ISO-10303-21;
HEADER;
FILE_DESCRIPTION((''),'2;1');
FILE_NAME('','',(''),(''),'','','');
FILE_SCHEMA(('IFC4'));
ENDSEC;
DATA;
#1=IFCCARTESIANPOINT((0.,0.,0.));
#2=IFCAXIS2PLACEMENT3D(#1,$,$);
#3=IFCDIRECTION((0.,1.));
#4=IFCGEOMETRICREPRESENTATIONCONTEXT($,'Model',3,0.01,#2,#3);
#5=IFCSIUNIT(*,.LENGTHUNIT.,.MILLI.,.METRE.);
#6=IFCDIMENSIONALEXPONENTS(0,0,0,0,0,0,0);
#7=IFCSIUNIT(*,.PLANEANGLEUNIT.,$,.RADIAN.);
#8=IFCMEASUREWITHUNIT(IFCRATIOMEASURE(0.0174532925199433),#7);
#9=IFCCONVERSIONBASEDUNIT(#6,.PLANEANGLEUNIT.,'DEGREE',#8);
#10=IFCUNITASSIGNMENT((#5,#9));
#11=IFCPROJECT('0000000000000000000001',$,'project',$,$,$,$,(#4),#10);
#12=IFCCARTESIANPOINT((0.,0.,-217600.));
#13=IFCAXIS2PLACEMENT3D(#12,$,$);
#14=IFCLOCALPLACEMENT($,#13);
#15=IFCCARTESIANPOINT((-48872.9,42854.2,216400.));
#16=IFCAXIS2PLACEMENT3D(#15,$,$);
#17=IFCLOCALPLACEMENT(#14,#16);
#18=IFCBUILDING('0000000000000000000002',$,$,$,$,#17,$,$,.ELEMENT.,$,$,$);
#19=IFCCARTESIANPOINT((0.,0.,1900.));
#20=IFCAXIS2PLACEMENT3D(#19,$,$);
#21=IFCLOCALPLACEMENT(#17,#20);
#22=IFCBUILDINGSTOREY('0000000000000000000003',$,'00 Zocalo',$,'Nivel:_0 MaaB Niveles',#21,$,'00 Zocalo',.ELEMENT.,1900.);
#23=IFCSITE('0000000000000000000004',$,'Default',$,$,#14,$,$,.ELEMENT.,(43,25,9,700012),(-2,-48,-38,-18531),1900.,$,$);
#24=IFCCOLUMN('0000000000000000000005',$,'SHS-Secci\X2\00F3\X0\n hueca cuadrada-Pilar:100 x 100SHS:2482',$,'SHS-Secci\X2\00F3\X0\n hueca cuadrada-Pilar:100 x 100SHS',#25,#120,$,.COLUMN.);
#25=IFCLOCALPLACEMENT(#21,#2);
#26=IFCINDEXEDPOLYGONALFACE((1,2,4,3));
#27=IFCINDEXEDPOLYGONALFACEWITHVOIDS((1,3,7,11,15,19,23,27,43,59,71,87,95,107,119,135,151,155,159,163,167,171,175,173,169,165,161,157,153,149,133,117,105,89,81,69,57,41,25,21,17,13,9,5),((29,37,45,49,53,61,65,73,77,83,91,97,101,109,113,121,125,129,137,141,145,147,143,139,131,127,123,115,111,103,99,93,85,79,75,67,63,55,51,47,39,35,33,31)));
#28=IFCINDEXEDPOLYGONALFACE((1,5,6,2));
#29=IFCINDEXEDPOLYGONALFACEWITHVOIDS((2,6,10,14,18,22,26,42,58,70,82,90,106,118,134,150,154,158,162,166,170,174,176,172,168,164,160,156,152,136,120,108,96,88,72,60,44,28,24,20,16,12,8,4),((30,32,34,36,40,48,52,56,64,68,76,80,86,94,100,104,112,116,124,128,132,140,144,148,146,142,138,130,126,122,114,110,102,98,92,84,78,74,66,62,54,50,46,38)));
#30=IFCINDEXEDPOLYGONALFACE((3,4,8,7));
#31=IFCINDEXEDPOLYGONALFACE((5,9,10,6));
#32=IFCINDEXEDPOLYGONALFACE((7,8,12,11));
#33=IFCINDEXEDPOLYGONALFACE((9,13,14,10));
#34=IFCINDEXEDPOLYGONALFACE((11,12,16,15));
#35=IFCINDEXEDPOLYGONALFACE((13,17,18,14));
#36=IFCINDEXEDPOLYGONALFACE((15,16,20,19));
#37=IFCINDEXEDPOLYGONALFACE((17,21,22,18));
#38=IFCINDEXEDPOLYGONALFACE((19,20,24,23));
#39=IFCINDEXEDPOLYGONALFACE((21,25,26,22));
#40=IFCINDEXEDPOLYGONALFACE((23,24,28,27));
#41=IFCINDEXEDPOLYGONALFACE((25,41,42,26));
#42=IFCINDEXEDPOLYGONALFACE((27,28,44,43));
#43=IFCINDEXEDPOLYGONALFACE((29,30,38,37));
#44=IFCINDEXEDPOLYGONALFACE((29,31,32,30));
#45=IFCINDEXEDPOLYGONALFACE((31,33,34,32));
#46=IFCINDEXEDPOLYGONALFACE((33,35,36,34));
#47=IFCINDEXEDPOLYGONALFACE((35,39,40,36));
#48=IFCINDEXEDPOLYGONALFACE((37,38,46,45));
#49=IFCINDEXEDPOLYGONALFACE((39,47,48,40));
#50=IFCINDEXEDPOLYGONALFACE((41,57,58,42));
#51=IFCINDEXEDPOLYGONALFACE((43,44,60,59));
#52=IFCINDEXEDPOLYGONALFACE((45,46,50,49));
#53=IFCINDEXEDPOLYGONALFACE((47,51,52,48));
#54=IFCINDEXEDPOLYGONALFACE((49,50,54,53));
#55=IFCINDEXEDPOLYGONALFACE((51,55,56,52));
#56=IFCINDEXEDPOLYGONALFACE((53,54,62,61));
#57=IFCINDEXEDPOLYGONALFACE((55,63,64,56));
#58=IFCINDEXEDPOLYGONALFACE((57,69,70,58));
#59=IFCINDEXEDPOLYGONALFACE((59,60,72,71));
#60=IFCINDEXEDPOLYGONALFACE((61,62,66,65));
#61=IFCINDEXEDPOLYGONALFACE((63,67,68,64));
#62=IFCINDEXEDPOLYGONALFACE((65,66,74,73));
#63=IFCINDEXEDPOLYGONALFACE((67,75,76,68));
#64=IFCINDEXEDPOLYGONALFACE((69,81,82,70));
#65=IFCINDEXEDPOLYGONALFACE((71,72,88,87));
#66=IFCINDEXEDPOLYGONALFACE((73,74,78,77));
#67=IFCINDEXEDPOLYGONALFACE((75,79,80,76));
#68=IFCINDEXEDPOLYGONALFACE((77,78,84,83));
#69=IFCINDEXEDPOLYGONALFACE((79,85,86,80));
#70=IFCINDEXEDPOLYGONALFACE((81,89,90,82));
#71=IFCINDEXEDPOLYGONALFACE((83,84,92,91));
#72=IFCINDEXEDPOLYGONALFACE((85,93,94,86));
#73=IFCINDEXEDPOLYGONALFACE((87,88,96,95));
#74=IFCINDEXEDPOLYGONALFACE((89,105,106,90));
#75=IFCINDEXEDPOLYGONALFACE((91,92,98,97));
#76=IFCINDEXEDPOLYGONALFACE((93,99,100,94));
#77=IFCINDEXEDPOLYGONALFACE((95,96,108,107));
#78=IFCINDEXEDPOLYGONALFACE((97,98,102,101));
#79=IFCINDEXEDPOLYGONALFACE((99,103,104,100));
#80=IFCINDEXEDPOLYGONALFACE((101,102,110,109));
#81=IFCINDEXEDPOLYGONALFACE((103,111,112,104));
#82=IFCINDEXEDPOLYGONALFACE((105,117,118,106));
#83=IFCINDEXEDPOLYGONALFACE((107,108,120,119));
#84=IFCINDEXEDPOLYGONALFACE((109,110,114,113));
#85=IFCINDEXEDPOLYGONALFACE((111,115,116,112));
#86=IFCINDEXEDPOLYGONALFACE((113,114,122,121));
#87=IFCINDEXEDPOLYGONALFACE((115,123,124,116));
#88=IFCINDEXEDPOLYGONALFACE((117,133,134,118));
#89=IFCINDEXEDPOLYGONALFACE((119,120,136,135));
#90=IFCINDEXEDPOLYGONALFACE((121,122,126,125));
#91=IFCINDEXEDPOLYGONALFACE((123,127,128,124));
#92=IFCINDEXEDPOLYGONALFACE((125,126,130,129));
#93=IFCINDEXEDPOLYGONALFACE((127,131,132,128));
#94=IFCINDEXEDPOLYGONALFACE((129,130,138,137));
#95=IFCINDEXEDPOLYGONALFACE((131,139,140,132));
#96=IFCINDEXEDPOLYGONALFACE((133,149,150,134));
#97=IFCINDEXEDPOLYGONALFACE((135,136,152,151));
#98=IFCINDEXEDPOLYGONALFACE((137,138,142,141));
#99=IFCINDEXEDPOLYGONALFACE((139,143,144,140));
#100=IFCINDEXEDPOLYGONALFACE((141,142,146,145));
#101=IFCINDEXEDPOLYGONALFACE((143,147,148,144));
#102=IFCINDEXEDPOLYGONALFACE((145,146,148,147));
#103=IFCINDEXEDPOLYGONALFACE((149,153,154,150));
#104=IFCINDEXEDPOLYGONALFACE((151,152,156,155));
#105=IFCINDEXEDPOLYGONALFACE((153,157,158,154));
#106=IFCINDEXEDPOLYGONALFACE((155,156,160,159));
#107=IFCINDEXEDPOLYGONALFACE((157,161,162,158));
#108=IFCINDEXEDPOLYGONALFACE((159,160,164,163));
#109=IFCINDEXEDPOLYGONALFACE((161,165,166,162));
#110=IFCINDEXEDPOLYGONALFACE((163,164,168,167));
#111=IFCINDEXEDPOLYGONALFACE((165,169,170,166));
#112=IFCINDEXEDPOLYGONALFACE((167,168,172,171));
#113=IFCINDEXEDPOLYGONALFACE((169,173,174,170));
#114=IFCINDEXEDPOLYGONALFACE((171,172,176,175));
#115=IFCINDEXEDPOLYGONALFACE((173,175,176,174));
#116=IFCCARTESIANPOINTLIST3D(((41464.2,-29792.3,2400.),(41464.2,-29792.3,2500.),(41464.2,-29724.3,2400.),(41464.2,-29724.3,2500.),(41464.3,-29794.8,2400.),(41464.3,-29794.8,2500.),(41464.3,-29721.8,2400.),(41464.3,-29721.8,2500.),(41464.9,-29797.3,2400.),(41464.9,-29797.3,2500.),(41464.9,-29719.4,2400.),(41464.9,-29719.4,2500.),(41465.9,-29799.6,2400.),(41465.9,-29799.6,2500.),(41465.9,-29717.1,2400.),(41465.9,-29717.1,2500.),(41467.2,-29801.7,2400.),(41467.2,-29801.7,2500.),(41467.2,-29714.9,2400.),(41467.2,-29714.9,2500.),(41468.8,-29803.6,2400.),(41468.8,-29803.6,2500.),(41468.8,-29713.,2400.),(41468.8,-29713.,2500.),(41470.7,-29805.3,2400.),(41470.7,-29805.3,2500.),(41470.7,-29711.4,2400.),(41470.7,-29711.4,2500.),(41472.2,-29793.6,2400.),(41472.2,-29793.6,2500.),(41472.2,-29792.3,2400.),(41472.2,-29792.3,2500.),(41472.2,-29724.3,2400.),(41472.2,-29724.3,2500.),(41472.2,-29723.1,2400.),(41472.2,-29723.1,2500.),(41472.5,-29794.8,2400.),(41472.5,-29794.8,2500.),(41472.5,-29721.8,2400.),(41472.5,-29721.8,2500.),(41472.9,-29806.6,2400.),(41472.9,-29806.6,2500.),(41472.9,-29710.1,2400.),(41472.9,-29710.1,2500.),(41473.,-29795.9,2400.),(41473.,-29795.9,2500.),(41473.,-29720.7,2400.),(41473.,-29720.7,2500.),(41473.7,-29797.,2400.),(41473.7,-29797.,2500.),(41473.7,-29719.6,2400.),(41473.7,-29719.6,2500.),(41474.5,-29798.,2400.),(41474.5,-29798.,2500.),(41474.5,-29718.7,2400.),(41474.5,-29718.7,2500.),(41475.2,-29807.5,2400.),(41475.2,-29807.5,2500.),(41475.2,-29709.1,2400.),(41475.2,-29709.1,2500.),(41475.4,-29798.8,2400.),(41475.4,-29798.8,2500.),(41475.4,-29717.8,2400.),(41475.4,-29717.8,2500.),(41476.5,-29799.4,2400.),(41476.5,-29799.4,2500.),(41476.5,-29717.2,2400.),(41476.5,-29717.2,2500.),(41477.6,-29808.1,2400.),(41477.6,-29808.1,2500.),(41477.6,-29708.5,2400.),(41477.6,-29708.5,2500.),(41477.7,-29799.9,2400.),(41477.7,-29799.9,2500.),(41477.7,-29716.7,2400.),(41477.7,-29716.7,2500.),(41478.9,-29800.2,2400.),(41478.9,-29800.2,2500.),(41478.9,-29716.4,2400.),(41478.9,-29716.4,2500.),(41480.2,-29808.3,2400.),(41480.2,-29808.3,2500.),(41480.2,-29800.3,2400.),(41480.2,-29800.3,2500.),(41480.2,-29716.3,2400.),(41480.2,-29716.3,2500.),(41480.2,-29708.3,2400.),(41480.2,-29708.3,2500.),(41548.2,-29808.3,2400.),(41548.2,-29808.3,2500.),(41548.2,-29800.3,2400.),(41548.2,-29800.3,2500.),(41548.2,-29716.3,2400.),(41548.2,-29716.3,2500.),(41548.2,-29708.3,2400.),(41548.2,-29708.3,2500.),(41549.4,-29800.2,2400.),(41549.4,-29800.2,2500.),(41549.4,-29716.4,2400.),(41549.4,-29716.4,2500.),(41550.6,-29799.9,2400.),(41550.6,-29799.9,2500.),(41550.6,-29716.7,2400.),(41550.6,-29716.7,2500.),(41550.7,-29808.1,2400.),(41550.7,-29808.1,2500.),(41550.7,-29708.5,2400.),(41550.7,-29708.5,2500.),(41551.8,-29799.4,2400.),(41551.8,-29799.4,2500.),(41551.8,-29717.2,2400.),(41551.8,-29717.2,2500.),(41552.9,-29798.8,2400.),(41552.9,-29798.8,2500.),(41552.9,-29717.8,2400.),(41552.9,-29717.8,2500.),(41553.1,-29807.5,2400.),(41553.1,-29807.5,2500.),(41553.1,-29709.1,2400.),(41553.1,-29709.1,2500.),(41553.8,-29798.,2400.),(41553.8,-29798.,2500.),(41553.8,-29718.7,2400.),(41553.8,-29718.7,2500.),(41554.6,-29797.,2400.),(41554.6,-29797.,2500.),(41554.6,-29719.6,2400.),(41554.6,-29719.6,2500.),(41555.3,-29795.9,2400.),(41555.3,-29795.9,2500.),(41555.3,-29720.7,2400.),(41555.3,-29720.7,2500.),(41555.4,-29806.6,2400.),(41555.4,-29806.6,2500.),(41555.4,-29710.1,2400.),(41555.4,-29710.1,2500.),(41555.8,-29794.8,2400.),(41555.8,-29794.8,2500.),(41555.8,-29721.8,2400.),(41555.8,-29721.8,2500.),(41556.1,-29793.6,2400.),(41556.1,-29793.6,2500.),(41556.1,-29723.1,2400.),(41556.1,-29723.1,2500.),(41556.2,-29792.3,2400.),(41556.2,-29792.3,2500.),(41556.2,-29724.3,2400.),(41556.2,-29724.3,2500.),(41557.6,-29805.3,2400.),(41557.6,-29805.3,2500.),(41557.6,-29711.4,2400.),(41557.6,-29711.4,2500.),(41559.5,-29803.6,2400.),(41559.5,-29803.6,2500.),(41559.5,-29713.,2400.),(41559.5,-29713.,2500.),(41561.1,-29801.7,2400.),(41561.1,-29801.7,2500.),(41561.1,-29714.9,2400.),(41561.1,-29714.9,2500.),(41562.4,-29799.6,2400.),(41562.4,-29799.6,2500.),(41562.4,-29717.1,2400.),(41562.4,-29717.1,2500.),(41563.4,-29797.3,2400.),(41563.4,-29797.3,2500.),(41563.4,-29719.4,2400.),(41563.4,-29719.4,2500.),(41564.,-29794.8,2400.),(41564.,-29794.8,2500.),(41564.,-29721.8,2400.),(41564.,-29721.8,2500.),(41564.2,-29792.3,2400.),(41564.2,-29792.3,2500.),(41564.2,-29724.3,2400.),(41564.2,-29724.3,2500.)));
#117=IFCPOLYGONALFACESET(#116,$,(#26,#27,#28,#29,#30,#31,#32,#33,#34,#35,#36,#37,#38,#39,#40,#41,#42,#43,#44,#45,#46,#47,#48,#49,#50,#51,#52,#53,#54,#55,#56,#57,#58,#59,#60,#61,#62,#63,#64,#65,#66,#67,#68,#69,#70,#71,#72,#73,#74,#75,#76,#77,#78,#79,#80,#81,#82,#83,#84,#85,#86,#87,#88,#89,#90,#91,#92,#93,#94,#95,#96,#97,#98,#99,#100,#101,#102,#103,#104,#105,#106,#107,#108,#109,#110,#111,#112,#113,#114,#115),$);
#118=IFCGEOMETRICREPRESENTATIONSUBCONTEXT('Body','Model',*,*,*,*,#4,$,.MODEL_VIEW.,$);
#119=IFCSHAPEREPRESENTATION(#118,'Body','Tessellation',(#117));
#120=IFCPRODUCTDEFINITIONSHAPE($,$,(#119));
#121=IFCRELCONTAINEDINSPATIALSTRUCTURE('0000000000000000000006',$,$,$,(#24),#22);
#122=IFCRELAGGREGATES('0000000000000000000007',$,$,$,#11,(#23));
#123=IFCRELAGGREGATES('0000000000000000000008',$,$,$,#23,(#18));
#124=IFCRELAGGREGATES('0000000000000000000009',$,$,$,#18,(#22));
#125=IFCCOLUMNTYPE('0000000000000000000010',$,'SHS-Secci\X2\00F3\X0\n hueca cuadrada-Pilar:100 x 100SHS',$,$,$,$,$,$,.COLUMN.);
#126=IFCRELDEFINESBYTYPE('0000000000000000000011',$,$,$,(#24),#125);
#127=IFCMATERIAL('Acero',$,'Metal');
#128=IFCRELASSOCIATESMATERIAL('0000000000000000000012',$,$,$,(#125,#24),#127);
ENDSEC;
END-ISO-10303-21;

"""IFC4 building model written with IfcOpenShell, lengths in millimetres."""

from ifc_helpers import new_model, entity, si_unit, converted_unit, direction, frame, origin, place, context, subcontext, project, spatial, indexed_curve, outline, extrude, source, transform, mapped, material, type_object, type_shapes, element, save


model = new_model("IFC4")

# Units and contexts
model_context = context("Model", 3, precision=0.01, world=origin(), true_north=direction((0.0, 1.0)))
body_context = subcontext(model_context, "Body", "Model", "MODEL_VIEW")
ifc_project = project(units=[si_unit("LENGTHUNIT", "METRE", prefix="MILLI"), converted_unit("PLANEANGLEUNIT", "DEGREE", entity("IfcRatioMeasure", 0.0174532925199433), si_unit("PLANEANGLEUNIT", "RADIAN"), dimensions=[0, 0, 0, 0, 0, 0, 0])], contexts=[model_context])

# Site, building, storey
site_placement = place(None, frame((0.0, 0.0, -217600.0)))
site = spatial("IfcSite", under=ifc_project, at=site_placement, Name="Default", CompositionType="ELEMENT", RefLatitude=(43, 25, 9, 700012), RefLongitude=(-2, -48, -38, -18531), RefElevation=1900.0)
building_placement = place(site_placement, frame((-48872.9, 42854.2, 216400.0)))
building = spatial("IfcBuilding", under=site, at=building_placement, CompositionType="ELEMENT")
storey_placement = place(building_placement, frame((0.0, 0.0, 1900.0)))
storey = spatial("IfcBuildingStorey", under=building, at=storey_placement, Name="00 Zocalo", ObjectType="Nivel:_0 MaaB Niveles", LongName="00 Zocalo", CompositionType="ELEMENT", Elevation=1900.0)

# Column
ifc_material = material(Name="Acero", Category="Metal")
column_type_1 = type_object("IfcColumnType", Name="SHS-Sección hueca cuadrada-Pilar:100 x 100SHS", PredefinedType="COLUMN", material=ifc_material)
shared_shape_1 = source(origin(), body_context, "Body", "SweptSolid", [
    extrude(outline(indexed_curve([(34.0, -50.0), (36.5, -49.8), (38.9, -49.2), (41.3, -48.3), (43.4, -46.9), (45.3, -45.3), (46.9, -43.4), (48.3, -41.3), (49.2, -38.9), (49.8, -36.5), (50.0, -34.0), (50.0, 34.0), (49.8, 36.5), (49.2, 38.9), (48.3, 41.3), (46.9, 43.4), (45.3, 45.3), (43.4, 46.9), (41.3, 48.3), (38.9, 49.2), (36.5, 49.8), (34.0, 50.0), (-34.0, 50.0), (-36.5, 49.8), (-38.9, 49.2), (-41.3, 48.3), (-43.4, 46.9), (-45.3, 45.3), (-46.9, 43.4), (-48.3, 41.3), (-49.2, 38.9), (-49.8, 36.5), (-50.0, 34.0), (-50.0, -34.0), (-49.8, -36.5), (-49.2, -38.9), (-48.3, -41.3), (-46.9, -43.4), (-45.3, -45.3), (-43.4, -46.9), (-41.3, -48.3), (-38.9, -49.2), (-36.5, -49.8), (-34.0, -50.0), (34.0, -50.0)], self_intersect=False), holes=[indexed_curve([(34.0, -42.0), (-34.0, -42.0), (-35.3, -41.9), (-36.5, -41.6), (-37.6, -41.1), (-38.7, -40.5), (-39.7, -39.7), (-40.5, -38.7), (-41.1, -37.6), (-41.6, -36.5), (-41.9, -35.3), (-42.0, -34.0), (-42.0, 34.0), (-41.9, 35.3), (-41.6, 36.5), (-41.1, 37.6), (-40.5, 38.7), (-39.7, 39.7), (-38.7, 40.5), (-37.6, 41.1), (-36.5, 41.6), (-35.3, 41.9), (-34.0, 42.0), (34.0, 42.0), (35.3, 41.9), (36.5, 41.6), (37.6, 41.1), (38.7, 40.5), (39.7, 39.7), (40.5, 38.7), (41.1, 37.6), (41.6, 36.5), (41.9, 35.3), (42.0, 34.0), (42.0, -34.0), (41.9, -35.3), (41.6, -36.5), (41.1, -37.6), (40.5, -38.7), (39.7, -39.7), (38.7, -40.5), (37.6, -41.1), (36.5, -41.6), (35.3, -41.9), (34.0, -42.0)], self_intersect=False)]), frame((0.0, 0.0, 4300.0)), (0.0, 0.0, 1.0), 100.0),
])
type_shapes(column_type_1, [shared_shape_1])
column_1_placement = place(storey_placement, frame((41514.2, -29758.3, -1900.0), z_axis=(0.0, 0.0, 1.0), x_axis=(0.0, -1.0, 0.0)))
element("IfcColumn", 1, at=column_1_placement, inside=storey, type_object=column_type_1, material=ifc_material, Name="SHS-Sección hueca cuadrada-Pilar:100 x 100SHS:2482", ObjectType="SHS-Sección hueca cuadrada-Pilar:100 x 100SHS", PredefinedType="COLUMN", context=body_context, shape_type="MappedRepresentation", body=[
    mapped(shared_shape_1, transform((0.0, 0.0, 0.0), scale=1.0)),
])

save(model, "model.ifc")
